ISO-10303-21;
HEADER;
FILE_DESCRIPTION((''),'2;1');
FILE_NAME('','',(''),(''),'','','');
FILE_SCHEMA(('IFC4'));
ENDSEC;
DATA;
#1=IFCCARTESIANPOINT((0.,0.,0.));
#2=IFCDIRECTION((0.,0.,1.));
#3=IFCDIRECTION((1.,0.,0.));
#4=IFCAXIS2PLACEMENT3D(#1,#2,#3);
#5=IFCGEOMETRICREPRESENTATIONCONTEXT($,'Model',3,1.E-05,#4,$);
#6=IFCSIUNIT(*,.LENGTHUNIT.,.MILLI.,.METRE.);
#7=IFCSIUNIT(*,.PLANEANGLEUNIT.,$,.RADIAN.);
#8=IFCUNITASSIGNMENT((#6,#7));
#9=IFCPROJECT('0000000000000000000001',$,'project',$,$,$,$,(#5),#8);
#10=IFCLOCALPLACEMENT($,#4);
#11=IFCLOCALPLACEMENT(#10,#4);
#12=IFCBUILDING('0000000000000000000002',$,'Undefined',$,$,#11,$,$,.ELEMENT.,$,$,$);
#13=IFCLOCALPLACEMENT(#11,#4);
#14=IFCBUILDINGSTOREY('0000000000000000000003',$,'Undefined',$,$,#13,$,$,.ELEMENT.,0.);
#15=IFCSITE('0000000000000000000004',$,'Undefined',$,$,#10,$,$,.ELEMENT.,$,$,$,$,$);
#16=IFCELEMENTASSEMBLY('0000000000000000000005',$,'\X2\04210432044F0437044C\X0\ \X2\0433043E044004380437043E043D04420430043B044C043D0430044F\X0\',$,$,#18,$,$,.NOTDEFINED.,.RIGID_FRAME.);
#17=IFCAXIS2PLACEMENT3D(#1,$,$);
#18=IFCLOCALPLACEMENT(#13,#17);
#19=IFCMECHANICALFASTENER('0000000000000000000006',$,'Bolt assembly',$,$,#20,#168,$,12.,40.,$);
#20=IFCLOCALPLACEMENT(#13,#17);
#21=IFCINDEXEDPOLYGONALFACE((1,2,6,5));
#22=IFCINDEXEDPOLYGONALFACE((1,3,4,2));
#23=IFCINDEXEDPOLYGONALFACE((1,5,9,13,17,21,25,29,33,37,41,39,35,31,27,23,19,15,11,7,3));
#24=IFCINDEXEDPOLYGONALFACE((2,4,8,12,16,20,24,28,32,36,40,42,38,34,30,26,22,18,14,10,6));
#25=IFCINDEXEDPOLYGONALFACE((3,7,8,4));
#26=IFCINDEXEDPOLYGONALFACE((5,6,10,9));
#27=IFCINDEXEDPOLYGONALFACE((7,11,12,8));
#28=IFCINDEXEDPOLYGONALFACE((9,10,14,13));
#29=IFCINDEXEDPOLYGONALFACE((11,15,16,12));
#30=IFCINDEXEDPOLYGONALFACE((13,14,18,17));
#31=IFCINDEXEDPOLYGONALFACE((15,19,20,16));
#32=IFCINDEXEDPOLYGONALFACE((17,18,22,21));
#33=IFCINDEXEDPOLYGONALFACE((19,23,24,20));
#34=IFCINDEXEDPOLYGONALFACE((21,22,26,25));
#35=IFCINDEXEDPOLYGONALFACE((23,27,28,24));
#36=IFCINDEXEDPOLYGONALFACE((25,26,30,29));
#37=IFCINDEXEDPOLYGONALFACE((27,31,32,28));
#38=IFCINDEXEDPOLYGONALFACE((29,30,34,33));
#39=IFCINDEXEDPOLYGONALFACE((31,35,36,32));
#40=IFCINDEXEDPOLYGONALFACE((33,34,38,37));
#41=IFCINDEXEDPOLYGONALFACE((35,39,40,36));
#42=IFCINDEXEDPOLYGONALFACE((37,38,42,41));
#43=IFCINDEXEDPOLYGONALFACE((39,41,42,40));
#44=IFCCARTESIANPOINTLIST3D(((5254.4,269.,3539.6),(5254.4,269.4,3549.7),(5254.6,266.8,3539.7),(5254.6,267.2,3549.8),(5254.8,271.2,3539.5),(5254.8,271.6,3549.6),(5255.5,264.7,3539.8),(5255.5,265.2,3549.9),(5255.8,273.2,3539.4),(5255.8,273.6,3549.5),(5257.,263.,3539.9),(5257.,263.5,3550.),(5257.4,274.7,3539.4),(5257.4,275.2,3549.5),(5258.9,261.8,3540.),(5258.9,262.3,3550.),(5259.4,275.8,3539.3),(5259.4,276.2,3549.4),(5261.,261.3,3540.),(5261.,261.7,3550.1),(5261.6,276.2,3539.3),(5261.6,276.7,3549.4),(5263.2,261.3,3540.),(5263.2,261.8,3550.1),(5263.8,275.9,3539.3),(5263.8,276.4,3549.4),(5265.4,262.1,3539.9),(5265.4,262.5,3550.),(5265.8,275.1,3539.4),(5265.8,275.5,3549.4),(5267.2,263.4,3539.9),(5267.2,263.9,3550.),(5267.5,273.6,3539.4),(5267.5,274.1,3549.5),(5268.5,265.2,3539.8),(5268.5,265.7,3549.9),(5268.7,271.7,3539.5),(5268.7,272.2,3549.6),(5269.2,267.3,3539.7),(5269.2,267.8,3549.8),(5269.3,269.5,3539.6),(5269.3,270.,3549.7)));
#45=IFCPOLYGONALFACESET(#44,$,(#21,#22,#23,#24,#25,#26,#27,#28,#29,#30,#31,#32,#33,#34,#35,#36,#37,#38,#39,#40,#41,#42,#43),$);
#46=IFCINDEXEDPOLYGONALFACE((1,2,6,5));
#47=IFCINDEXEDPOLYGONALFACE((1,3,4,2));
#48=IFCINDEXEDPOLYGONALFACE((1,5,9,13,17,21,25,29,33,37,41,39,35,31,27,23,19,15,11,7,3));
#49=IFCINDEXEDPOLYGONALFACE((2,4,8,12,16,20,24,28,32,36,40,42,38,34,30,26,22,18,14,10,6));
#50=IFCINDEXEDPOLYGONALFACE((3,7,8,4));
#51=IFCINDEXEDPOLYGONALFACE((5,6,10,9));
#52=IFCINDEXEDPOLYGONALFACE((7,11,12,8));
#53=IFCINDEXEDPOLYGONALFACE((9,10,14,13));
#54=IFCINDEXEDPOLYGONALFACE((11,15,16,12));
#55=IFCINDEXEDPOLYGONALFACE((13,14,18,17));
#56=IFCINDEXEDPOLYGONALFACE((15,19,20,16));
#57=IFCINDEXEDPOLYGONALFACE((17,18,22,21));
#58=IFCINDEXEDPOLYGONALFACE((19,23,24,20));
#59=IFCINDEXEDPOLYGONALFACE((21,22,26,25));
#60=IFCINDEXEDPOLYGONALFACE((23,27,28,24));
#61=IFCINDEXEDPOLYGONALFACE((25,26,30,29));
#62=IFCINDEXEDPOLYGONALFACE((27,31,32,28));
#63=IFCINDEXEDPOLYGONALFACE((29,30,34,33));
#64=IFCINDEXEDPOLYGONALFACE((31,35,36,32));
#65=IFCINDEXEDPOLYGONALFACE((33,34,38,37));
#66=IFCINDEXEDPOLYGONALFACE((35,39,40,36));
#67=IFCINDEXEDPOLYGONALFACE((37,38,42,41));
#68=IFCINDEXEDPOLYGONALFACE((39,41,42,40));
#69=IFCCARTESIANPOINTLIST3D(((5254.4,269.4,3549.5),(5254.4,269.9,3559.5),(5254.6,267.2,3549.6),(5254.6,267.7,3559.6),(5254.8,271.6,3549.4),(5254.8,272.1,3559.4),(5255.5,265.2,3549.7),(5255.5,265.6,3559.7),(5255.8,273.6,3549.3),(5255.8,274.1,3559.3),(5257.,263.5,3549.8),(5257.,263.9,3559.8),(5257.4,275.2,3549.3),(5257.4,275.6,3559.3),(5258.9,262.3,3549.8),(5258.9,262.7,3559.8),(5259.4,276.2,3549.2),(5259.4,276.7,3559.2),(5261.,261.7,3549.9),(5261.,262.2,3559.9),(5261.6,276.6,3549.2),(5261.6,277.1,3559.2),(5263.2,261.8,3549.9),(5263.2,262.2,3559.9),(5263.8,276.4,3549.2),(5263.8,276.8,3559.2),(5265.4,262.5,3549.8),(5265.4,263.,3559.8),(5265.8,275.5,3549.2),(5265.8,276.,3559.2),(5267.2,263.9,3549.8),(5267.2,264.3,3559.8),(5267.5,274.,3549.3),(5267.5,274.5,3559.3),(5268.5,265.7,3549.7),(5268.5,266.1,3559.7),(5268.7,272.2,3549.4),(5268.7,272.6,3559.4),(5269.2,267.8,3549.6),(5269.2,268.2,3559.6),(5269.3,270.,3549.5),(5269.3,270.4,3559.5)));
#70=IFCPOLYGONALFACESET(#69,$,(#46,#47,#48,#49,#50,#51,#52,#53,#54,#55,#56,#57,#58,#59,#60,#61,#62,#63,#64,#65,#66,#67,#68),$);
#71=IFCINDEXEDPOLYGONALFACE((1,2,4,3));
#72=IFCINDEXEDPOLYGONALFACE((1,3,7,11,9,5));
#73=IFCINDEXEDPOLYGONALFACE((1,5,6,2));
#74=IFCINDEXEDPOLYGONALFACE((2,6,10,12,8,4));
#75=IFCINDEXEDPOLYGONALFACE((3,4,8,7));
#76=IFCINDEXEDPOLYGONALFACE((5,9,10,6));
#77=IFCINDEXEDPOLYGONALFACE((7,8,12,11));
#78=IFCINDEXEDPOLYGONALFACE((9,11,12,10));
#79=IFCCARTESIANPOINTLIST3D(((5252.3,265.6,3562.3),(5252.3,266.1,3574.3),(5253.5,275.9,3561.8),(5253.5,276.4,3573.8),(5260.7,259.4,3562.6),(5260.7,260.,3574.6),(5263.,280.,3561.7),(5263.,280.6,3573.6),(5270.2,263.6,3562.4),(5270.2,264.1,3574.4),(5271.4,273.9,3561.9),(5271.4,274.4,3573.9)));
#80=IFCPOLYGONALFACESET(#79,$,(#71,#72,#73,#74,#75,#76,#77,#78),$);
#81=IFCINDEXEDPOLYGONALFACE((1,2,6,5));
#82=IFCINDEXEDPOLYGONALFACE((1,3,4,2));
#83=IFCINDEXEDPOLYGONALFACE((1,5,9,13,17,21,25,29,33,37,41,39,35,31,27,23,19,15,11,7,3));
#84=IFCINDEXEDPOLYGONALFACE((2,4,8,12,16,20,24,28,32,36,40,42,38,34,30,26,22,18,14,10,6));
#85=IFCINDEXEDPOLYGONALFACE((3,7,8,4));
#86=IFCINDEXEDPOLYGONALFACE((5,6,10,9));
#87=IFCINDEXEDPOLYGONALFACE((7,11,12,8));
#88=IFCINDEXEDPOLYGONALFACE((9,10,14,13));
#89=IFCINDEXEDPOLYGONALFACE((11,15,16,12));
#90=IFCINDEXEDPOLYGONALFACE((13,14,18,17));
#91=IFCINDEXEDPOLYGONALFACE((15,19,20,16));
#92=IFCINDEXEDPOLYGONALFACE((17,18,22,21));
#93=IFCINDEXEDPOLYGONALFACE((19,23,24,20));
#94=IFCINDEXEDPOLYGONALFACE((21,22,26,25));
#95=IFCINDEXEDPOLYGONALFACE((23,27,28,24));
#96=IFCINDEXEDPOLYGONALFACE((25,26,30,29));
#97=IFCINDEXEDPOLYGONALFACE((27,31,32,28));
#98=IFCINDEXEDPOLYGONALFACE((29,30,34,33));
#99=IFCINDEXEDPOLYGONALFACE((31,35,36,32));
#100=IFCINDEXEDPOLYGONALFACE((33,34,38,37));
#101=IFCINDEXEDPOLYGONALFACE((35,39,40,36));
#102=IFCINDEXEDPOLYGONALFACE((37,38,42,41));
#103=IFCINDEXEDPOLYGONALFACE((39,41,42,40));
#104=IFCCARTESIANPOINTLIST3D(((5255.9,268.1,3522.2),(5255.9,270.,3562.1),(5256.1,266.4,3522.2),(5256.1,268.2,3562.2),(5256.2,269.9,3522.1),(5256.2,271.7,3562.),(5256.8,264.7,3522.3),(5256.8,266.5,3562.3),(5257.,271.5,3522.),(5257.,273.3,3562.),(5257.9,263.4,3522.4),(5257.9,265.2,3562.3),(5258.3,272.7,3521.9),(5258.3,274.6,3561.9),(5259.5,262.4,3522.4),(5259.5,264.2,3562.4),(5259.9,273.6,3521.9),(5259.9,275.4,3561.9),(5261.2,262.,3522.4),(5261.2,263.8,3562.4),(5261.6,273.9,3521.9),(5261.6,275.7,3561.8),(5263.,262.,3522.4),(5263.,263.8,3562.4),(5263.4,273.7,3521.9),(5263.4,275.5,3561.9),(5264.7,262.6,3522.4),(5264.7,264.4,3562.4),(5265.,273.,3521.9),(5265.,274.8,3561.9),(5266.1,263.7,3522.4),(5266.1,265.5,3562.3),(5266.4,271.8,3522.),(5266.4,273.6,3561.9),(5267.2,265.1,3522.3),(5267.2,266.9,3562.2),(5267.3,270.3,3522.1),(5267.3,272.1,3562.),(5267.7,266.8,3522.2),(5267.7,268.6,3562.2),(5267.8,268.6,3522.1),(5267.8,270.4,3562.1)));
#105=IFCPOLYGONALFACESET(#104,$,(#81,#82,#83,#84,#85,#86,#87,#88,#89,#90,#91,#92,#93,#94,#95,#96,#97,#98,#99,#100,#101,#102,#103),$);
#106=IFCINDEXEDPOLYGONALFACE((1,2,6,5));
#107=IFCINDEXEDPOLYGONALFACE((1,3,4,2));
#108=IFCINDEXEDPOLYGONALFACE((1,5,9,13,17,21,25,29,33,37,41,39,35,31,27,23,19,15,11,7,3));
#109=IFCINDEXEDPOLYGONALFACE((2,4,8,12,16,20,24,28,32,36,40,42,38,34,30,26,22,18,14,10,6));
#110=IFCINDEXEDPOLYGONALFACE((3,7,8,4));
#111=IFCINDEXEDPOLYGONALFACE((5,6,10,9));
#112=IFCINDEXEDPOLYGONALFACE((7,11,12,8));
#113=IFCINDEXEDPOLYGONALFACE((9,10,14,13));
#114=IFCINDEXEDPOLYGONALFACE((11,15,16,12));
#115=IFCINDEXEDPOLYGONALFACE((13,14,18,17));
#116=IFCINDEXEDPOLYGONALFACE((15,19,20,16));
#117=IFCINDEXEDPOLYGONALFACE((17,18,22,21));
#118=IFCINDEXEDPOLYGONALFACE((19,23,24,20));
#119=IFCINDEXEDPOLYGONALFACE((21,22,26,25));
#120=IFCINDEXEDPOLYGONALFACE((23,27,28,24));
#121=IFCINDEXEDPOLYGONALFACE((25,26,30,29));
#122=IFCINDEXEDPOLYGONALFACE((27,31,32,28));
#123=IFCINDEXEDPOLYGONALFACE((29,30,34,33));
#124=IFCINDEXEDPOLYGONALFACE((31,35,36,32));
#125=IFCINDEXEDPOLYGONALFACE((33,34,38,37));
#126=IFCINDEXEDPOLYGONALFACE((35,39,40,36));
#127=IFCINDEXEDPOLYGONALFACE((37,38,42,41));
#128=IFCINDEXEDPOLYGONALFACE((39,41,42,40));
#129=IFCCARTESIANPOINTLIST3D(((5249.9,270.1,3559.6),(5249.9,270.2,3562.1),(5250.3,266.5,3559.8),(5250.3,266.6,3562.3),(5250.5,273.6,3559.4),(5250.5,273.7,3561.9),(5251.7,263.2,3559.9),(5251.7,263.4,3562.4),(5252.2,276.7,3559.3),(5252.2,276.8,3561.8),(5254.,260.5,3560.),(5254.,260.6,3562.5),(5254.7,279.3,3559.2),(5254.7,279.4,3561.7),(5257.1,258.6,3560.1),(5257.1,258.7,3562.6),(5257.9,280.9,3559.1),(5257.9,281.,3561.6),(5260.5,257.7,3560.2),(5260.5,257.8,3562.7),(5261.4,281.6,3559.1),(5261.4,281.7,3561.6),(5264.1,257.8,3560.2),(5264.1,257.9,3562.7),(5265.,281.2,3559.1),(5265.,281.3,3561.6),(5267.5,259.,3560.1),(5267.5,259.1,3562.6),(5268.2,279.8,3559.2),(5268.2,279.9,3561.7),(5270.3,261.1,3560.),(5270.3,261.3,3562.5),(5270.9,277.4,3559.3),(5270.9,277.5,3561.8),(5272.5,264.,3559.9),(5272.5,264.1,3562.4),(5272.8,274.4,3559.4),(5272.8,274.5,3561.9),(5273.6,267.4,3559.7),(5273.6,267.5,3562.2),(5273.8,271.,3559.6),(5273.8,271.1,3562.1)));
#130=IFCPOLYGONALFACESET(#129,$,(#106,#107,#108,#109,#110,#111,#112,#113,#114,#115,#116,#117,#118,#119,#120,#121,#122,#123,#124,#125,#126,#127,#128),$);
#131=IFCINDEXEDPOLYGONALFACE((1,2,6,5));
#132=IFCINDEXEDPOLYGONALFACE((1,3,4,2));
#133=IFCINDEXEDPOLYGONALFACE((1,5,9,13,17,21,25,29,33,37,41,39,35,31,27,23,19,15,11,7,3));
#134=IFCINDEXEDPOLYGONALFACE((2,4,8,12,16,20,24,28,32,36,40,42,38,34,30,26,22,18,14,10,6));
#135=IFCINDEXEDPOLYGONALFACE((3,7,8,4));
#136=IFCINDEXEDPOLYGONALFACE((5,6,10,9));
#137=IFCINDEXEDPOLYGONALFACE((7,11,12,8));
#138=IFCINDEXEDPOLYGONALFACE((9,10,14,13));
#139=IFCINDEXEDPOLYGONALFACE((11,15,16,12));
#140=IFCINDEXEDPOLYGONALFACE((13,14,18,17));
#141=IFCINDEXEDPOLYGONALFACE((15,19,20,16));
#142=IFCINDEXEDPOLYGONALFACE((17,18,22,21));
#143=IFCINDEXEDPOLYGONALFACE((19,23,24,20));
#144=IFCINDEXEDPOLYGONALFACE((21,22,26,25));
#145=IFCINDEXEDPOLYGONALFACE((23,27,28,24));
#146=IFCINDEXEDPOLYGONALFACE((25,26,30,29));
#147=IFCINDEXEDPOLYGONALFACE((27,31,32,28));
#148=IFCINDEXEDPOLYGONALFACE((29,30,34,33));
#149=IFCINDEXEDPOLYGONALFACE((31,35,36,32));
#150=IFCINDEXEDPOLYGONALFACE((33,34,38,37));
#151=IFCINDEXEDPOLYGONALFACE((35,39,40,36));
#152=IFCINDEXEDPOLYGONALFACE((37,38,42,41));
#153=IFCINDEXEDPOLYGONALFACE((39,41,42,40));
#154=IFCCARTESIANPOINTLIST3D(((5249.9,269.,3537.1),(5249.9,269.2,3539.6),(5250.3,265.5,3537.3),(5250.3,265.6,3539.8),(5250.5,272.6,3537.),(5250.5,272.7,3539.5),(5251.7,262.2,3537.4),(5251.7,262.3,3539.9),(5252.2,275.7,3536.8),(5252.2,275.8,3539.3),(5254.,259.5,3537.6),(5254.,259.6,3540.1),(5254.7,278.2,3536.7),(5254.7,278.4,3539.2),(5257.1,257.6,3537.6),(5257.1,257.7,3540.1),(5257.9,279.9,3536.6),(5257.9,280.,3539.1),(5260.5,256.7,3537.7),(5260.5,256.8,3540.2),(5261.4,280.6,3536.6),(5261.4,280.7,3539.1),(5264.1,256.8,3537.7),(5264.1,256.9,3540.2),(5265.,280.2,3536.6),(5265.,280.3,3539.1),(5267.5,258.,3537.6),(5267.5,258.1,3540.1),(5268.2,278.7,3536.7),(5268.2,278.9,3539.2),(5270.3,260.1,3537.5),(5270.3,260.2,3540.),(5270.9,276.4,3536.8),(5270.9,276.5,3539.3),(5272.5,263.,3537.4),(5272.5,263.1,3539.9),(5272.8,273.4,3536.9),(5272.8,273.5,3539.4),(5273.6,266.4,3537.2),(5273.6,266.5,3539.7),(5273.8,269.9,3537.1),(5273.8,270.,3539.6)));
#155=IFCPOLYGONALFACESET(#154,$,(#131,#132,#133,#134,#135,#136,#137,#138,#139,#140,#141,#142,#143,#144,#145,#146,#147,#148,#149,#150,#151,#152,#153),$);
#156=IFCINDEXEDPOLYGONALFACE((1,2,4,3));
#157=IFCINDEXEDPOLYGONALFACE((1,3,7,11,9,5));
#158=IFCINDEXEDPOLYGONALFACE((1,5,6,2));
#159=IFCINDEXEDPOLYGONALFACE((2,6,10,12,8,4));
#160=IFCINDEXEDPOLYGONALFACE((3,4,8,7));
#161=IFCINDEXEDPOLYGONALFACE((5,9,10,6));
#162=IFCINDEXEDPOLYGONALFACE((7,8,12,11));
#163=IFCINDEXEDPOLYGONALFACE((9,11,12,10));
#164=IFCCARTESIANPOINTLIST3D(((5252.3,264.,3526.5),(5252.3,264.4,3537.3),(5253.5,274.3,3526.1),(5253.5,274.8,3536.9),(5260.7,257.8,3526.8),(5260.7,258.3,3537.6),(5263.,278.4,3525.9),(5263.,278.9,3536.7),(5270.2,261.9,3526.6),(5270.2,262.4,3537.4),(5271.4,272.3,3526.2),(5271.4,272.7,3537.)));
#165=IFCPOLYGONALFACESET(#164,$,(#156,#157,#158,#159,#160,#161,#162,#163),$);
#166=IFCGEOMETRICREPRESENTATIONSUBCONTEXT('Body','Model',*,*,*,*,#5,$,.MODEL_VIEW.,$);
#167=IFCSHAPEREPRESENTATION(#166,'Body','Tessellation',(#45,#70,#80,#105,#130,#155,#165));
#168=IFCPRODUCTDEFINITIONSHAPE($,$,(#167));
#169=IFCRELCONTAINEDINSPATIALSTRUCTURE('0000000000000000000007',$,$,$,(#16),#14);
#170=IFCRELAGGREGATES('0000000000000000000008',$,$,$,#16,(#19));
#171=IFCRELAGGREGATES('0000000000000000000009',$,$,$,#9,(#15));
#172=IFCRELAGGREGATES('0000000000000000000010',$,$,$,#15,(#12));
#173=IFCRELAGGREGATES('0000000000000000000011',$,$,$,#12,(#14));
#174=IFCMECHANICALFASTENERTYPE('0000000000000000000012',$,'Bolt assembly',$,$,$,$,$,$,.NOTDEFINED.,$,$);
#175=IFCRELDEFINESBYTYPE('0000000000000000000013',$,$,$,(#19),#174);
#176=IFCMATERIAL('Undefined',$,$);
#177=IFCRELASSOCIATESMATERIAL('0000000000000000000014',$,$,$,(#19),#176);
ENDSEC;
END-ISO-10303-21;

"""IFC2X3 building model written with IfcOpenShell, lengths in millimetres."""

from ifc_helpers import new_model, si_unit, frame, origin_with_axes, origin_2d_with_axis, place, context, subcontext, project, spatial, polyline, circle, outline, extrude, source, transform, mapped, material, type_object, element, aggregate, save


model = new_model("IFC2X3")

# Units and contexts
model_context = context("Model", 3, precision=1e-05, world=origin_with_axes())
body_context = subcontext(model_context, "Body", "Model", "MODEL_VIEW")
ifc_project = project(units=[si_unit("LENGTHUNIT", "METRE", prefix="MILLI"), si_unit("PLANEANGLEUNIT", "RADIAN")], contexts=[model_context])

# Site, building, storey
site_placement = place(None, origin_with_axes())
site = spatial("IfcSite", under=ifc_project, at=site_placement, Name="Undefined", CompositionType="ELEMENT")
building_placement = place(site_placement, origin_with_axes())
building = spatial("IfcBuilding", under=site, at=building_placement, Name="Undefined", CompositionType="ELEMENT")
storey_placement = place(building_placement, origin_with_axes())
storey = spatial("IfcBuildingStorey", under=building, at=storey_placement, Name="Undefined", CompositionType="ELEMENT", Elevation=0.0)

# Element assembly
assembly_1_placement = place(storey_placement, origin_with_axes())
assembly_1 = element("IfcElementAssembly", 1, at=assembly_1_placement, inside=storey, Name="Связь горизонтальная", AssemblyPlace="NOTDEFINED", PredefinedType="RIGID_FRAME")

# Mechanical fastener
ifc_material_1 = material(Name="Undefined")
mechanical_fastener_type = type_object("IfcMechanicalFastenerType", Name="Bolt assembly")
shared_shape_1 = source(origin_with_axes(), body_context, "Body", "SweptSolid", [
    extrude(circle(Radius=7.5, at=origin_2d_with_axis()), frame((0.0, -0.1, 0.0), z_axis=(0.0, 1.0, 0.0), x_axis=(1.0, 0.0, 0.0)), (0.0, 0.0, 1.0), 10.1),
    extrude(circle(Radius=7.5, at=origin_2d_with_axis()), frame((0.0, -9.9, 0.0), z_axis=(0.0, 1.0, 0.0), x_axis=(1.0, 0.0, 0.0)), (0.0, 0.0, 1.0), 10.0),
    extrude(outline(polyline([(10.4, 0.0), (5.2, 9.0), (-5.2, 9.0), (-10.4, 0.0), (-5.2, -9.0), (5.2, -9.0), (10.4, 0.0)])), frame((0.0, -24.5, 0.0), z_axis=(0.0, 1.0, 0.0), x_axis=(1.0, 0.0, 0.0)), (0.0, 0.0, 1.0), 12.0),
    extrude(circle(Radius=6.0, at=origin_2d_with_axis()), frame((0.0, -12.5, 0.0), z_axis=(0.0, 1.0, 0.0), x_axis=(1.0, 0.0, 0.0)), (0.0, 0.0, 1.0), 40.0),
    extrude(circle(Radius=12.0, at=origin_2d_with_axis()), frame((0.0, -12.5, 0.0), z_axis=(0.0, 1.0, 0.0), x_axis=(1.0, 0.0, 0.0)), (0.0, 0.0, 1.0), 2.5),
    extrude(circle(Radius=12.0, at=origin_2d_with_axis()), frame((0.0, 10.0, 0.0), z_axis=(0.0, 1.0, 0.0), x_axis=(1.0, 0.0, 0.0)), (0.0, 0.0, 1.0), 2.5),
    extrude(outline(polyline([(10.4, 0.0), (5.2, 9.0), (-5.2, 9.0), (-10.4, 0.0), (-5.2, -9.0), (5.2, -9.0), (10.4, 0.0)])), frame((0.0, 12.5, 0.0), z_axis=(0.0, 1.0, 0.0), x_axis=(1.0, 0.0, 0.0)), (0.0, 0.0, 1.0), 10.8),
])
mechanical_fastener_1_placement = place(assembly_1_placement, frame((5261.9, 269.2, 3549.6), z_axis=(-0.593795, -0.803786, 0.036536), x_axis=(-0.804616, 0.593183, -0.026963)))
mechanical_fastener_1 = element("IfcMechanicalFastener", 2, at=mechanical_fastener_1_placement, type_object=mechanical_fastener_type, material=ifc_material_1, Name="Bolt assembly", NominalDiameter=12.0, NominalLength=40.0, context=body_context, shape_type="MappedRepresentation", body=[
    mapped(shared_shape_1, transform((0.0, 0.0, 0.0))),
])
aggregate(assembly_1, [mechanical_fastener_1])

save(model, "model.ifc")
